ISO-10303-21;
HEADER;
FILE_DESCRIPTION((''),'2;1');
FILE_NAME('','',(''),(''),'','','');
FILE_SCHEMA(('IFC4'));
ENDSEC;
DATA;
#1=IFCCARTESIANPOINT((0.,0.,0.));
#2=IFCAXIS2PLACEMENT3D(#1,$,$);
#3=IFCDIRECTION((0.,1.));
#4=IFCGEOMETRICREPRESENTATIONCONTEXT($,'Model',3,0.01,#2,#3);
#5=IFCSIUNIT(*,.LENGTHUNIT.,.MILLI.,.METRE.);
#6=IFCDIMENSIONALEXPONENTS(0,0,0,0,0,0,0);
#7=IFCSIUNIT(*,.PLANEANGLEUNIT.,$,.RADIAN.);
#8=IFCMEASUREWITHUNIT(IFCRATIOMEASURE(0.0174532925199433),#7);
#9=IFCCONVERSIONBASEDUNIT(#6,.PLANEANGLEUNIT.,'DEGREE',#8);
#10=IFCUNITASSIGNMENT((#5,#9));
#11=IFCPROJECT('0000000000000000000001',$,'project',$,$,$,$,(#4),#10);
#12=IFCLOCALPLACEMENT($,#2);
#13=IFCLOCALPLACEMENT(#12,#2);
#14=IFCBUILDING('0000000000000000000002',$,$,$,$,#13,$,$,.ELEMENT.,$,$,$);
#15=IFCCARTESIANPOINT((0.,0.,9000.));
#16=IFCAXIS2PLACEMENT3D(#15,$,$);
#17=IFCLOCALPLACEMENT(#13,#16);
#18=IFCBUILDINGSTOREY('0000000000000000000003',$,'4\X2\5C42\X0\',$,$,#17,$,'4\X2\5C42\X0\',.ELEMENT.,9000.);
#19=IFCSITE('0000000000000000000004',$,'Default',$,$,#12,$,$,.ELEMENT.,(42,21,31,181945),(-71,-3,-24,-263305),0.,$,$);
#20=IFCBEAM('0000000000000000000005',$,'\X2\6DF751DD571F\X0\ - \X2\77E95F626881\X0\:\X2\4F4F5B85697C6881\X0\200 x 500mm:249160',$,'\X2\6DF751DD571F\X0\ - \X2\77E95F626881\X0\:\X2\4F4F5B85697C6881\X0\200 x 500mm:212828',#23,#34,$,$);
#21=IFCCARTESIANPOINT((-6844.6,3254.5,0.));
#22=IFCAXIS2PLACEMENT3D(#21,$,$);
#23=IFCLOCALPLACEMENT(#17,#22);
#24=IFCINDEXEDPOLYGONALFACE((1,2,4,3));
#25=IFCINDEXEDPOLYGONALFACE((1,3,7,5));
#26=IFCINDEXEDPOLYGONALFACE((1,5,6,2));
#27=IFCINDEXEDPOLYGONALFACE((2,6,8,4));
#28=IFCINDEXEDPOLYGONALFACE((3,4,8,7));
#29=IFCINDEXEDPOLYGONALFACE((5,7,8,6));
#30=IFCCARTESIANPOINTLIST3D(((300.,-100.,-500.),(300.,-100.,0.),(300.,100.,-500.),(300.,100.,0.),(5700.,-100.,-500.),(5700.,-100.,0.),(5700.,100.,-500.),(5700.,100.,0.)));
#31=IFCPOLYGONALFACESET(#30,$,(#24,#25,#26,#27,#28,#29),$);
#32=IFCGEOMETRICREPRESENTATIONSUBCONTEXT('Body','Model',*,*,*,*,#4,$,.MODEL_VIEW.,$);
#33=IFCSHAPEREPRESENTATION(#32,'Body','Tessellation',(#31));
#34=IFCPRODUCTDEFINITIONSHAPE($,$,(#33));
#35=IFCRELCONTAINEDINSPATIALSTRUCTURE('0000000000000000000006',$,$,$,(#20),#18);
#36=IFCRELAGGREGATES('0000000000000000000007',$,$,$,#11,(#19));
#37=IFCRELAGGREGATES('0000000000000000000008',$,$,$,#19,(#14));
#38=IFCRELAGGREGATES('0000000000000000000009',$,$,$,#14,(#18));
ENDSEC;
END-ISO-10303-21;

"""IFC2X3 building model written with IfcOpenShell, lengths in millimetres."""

from ifc_helpers import new_model, entity, si_unit, converted_unit, direction, frame, frame_2d, origin, place, context, subcontext, project, spatial, rectangle, extrude, element, save


model = new_model("IFC2X3")

# Units and contexts
model_context = context("Model", 3, precision=0.01, world=origin(), true_north=direction((0.0, 1.0)))
body_context = subcontext(model_context, "Body", "Model", "MODEL_VIEW")
ifc_project = project(units=[si_unit("LENGTHUNIT", "METRE", prefix="MILLI"), converted_unit("PLANEANGLEUNIT", "DEGREE", entity("IfcRatioMeasure", 0.0174532925199433), si_unit("PLANEANGLEUNIT", "RADIAN"), dimensions=[0, 0, 0, 0, 0, 0, 0])], contexts=[model_context])

# Site, building, storey
site_placement = place(None, origin())
site = spatial("IfcSite", under=ifc_project, at=site_placement, Name="Default", CompositionType="ELEMENT", RefLatitude=(42, 21, 31, 181945), RefLongitude=(-71, -3, -24, -263305), RefElevation=0.0)
building_placement = place(site_placement, origin())
building = spatial("IfcBuilding", under=site, at=building_placement, CompositionType="ELEMENT")
storey_placement = place(building_placement, frame((0.0, 0.0, 9000.0)))
storey = spatial("IfcBuildingStorey", under=building, at=storey_placement, Name="4层", LongName="4层", CompositionType="ELEMENT", Elevation=9000.0)

# Beam
beam_placement = place(storey_placement, frame((-6844.6, 3254.5, 0.0)))
element("IfcBeam", 1, at=beam_placement, inside=storey, Name="混凝土 - 矩形梁:住宅楼梁200 x 500mm:249160", ObjectType="混凝土 - 矩形梁:住宅楼梁200 x 500mm:212828", context=body_context, shape_type="SweptSolid", body=[
    extrude(rectangle(XDim=500.0, YDim=200.0, at=frame_2d((0.0, 0.0), x_axis=(1.0, 0.0))), frame((300.0, 0.0, -250.0), z_axis=(1.0, 0.0, 0.0), x_axis=(0.0, 0.0, -1.0)), (0.0, 0.0, 1.0), 5400.0),
])

save(model, "model.ifc")
